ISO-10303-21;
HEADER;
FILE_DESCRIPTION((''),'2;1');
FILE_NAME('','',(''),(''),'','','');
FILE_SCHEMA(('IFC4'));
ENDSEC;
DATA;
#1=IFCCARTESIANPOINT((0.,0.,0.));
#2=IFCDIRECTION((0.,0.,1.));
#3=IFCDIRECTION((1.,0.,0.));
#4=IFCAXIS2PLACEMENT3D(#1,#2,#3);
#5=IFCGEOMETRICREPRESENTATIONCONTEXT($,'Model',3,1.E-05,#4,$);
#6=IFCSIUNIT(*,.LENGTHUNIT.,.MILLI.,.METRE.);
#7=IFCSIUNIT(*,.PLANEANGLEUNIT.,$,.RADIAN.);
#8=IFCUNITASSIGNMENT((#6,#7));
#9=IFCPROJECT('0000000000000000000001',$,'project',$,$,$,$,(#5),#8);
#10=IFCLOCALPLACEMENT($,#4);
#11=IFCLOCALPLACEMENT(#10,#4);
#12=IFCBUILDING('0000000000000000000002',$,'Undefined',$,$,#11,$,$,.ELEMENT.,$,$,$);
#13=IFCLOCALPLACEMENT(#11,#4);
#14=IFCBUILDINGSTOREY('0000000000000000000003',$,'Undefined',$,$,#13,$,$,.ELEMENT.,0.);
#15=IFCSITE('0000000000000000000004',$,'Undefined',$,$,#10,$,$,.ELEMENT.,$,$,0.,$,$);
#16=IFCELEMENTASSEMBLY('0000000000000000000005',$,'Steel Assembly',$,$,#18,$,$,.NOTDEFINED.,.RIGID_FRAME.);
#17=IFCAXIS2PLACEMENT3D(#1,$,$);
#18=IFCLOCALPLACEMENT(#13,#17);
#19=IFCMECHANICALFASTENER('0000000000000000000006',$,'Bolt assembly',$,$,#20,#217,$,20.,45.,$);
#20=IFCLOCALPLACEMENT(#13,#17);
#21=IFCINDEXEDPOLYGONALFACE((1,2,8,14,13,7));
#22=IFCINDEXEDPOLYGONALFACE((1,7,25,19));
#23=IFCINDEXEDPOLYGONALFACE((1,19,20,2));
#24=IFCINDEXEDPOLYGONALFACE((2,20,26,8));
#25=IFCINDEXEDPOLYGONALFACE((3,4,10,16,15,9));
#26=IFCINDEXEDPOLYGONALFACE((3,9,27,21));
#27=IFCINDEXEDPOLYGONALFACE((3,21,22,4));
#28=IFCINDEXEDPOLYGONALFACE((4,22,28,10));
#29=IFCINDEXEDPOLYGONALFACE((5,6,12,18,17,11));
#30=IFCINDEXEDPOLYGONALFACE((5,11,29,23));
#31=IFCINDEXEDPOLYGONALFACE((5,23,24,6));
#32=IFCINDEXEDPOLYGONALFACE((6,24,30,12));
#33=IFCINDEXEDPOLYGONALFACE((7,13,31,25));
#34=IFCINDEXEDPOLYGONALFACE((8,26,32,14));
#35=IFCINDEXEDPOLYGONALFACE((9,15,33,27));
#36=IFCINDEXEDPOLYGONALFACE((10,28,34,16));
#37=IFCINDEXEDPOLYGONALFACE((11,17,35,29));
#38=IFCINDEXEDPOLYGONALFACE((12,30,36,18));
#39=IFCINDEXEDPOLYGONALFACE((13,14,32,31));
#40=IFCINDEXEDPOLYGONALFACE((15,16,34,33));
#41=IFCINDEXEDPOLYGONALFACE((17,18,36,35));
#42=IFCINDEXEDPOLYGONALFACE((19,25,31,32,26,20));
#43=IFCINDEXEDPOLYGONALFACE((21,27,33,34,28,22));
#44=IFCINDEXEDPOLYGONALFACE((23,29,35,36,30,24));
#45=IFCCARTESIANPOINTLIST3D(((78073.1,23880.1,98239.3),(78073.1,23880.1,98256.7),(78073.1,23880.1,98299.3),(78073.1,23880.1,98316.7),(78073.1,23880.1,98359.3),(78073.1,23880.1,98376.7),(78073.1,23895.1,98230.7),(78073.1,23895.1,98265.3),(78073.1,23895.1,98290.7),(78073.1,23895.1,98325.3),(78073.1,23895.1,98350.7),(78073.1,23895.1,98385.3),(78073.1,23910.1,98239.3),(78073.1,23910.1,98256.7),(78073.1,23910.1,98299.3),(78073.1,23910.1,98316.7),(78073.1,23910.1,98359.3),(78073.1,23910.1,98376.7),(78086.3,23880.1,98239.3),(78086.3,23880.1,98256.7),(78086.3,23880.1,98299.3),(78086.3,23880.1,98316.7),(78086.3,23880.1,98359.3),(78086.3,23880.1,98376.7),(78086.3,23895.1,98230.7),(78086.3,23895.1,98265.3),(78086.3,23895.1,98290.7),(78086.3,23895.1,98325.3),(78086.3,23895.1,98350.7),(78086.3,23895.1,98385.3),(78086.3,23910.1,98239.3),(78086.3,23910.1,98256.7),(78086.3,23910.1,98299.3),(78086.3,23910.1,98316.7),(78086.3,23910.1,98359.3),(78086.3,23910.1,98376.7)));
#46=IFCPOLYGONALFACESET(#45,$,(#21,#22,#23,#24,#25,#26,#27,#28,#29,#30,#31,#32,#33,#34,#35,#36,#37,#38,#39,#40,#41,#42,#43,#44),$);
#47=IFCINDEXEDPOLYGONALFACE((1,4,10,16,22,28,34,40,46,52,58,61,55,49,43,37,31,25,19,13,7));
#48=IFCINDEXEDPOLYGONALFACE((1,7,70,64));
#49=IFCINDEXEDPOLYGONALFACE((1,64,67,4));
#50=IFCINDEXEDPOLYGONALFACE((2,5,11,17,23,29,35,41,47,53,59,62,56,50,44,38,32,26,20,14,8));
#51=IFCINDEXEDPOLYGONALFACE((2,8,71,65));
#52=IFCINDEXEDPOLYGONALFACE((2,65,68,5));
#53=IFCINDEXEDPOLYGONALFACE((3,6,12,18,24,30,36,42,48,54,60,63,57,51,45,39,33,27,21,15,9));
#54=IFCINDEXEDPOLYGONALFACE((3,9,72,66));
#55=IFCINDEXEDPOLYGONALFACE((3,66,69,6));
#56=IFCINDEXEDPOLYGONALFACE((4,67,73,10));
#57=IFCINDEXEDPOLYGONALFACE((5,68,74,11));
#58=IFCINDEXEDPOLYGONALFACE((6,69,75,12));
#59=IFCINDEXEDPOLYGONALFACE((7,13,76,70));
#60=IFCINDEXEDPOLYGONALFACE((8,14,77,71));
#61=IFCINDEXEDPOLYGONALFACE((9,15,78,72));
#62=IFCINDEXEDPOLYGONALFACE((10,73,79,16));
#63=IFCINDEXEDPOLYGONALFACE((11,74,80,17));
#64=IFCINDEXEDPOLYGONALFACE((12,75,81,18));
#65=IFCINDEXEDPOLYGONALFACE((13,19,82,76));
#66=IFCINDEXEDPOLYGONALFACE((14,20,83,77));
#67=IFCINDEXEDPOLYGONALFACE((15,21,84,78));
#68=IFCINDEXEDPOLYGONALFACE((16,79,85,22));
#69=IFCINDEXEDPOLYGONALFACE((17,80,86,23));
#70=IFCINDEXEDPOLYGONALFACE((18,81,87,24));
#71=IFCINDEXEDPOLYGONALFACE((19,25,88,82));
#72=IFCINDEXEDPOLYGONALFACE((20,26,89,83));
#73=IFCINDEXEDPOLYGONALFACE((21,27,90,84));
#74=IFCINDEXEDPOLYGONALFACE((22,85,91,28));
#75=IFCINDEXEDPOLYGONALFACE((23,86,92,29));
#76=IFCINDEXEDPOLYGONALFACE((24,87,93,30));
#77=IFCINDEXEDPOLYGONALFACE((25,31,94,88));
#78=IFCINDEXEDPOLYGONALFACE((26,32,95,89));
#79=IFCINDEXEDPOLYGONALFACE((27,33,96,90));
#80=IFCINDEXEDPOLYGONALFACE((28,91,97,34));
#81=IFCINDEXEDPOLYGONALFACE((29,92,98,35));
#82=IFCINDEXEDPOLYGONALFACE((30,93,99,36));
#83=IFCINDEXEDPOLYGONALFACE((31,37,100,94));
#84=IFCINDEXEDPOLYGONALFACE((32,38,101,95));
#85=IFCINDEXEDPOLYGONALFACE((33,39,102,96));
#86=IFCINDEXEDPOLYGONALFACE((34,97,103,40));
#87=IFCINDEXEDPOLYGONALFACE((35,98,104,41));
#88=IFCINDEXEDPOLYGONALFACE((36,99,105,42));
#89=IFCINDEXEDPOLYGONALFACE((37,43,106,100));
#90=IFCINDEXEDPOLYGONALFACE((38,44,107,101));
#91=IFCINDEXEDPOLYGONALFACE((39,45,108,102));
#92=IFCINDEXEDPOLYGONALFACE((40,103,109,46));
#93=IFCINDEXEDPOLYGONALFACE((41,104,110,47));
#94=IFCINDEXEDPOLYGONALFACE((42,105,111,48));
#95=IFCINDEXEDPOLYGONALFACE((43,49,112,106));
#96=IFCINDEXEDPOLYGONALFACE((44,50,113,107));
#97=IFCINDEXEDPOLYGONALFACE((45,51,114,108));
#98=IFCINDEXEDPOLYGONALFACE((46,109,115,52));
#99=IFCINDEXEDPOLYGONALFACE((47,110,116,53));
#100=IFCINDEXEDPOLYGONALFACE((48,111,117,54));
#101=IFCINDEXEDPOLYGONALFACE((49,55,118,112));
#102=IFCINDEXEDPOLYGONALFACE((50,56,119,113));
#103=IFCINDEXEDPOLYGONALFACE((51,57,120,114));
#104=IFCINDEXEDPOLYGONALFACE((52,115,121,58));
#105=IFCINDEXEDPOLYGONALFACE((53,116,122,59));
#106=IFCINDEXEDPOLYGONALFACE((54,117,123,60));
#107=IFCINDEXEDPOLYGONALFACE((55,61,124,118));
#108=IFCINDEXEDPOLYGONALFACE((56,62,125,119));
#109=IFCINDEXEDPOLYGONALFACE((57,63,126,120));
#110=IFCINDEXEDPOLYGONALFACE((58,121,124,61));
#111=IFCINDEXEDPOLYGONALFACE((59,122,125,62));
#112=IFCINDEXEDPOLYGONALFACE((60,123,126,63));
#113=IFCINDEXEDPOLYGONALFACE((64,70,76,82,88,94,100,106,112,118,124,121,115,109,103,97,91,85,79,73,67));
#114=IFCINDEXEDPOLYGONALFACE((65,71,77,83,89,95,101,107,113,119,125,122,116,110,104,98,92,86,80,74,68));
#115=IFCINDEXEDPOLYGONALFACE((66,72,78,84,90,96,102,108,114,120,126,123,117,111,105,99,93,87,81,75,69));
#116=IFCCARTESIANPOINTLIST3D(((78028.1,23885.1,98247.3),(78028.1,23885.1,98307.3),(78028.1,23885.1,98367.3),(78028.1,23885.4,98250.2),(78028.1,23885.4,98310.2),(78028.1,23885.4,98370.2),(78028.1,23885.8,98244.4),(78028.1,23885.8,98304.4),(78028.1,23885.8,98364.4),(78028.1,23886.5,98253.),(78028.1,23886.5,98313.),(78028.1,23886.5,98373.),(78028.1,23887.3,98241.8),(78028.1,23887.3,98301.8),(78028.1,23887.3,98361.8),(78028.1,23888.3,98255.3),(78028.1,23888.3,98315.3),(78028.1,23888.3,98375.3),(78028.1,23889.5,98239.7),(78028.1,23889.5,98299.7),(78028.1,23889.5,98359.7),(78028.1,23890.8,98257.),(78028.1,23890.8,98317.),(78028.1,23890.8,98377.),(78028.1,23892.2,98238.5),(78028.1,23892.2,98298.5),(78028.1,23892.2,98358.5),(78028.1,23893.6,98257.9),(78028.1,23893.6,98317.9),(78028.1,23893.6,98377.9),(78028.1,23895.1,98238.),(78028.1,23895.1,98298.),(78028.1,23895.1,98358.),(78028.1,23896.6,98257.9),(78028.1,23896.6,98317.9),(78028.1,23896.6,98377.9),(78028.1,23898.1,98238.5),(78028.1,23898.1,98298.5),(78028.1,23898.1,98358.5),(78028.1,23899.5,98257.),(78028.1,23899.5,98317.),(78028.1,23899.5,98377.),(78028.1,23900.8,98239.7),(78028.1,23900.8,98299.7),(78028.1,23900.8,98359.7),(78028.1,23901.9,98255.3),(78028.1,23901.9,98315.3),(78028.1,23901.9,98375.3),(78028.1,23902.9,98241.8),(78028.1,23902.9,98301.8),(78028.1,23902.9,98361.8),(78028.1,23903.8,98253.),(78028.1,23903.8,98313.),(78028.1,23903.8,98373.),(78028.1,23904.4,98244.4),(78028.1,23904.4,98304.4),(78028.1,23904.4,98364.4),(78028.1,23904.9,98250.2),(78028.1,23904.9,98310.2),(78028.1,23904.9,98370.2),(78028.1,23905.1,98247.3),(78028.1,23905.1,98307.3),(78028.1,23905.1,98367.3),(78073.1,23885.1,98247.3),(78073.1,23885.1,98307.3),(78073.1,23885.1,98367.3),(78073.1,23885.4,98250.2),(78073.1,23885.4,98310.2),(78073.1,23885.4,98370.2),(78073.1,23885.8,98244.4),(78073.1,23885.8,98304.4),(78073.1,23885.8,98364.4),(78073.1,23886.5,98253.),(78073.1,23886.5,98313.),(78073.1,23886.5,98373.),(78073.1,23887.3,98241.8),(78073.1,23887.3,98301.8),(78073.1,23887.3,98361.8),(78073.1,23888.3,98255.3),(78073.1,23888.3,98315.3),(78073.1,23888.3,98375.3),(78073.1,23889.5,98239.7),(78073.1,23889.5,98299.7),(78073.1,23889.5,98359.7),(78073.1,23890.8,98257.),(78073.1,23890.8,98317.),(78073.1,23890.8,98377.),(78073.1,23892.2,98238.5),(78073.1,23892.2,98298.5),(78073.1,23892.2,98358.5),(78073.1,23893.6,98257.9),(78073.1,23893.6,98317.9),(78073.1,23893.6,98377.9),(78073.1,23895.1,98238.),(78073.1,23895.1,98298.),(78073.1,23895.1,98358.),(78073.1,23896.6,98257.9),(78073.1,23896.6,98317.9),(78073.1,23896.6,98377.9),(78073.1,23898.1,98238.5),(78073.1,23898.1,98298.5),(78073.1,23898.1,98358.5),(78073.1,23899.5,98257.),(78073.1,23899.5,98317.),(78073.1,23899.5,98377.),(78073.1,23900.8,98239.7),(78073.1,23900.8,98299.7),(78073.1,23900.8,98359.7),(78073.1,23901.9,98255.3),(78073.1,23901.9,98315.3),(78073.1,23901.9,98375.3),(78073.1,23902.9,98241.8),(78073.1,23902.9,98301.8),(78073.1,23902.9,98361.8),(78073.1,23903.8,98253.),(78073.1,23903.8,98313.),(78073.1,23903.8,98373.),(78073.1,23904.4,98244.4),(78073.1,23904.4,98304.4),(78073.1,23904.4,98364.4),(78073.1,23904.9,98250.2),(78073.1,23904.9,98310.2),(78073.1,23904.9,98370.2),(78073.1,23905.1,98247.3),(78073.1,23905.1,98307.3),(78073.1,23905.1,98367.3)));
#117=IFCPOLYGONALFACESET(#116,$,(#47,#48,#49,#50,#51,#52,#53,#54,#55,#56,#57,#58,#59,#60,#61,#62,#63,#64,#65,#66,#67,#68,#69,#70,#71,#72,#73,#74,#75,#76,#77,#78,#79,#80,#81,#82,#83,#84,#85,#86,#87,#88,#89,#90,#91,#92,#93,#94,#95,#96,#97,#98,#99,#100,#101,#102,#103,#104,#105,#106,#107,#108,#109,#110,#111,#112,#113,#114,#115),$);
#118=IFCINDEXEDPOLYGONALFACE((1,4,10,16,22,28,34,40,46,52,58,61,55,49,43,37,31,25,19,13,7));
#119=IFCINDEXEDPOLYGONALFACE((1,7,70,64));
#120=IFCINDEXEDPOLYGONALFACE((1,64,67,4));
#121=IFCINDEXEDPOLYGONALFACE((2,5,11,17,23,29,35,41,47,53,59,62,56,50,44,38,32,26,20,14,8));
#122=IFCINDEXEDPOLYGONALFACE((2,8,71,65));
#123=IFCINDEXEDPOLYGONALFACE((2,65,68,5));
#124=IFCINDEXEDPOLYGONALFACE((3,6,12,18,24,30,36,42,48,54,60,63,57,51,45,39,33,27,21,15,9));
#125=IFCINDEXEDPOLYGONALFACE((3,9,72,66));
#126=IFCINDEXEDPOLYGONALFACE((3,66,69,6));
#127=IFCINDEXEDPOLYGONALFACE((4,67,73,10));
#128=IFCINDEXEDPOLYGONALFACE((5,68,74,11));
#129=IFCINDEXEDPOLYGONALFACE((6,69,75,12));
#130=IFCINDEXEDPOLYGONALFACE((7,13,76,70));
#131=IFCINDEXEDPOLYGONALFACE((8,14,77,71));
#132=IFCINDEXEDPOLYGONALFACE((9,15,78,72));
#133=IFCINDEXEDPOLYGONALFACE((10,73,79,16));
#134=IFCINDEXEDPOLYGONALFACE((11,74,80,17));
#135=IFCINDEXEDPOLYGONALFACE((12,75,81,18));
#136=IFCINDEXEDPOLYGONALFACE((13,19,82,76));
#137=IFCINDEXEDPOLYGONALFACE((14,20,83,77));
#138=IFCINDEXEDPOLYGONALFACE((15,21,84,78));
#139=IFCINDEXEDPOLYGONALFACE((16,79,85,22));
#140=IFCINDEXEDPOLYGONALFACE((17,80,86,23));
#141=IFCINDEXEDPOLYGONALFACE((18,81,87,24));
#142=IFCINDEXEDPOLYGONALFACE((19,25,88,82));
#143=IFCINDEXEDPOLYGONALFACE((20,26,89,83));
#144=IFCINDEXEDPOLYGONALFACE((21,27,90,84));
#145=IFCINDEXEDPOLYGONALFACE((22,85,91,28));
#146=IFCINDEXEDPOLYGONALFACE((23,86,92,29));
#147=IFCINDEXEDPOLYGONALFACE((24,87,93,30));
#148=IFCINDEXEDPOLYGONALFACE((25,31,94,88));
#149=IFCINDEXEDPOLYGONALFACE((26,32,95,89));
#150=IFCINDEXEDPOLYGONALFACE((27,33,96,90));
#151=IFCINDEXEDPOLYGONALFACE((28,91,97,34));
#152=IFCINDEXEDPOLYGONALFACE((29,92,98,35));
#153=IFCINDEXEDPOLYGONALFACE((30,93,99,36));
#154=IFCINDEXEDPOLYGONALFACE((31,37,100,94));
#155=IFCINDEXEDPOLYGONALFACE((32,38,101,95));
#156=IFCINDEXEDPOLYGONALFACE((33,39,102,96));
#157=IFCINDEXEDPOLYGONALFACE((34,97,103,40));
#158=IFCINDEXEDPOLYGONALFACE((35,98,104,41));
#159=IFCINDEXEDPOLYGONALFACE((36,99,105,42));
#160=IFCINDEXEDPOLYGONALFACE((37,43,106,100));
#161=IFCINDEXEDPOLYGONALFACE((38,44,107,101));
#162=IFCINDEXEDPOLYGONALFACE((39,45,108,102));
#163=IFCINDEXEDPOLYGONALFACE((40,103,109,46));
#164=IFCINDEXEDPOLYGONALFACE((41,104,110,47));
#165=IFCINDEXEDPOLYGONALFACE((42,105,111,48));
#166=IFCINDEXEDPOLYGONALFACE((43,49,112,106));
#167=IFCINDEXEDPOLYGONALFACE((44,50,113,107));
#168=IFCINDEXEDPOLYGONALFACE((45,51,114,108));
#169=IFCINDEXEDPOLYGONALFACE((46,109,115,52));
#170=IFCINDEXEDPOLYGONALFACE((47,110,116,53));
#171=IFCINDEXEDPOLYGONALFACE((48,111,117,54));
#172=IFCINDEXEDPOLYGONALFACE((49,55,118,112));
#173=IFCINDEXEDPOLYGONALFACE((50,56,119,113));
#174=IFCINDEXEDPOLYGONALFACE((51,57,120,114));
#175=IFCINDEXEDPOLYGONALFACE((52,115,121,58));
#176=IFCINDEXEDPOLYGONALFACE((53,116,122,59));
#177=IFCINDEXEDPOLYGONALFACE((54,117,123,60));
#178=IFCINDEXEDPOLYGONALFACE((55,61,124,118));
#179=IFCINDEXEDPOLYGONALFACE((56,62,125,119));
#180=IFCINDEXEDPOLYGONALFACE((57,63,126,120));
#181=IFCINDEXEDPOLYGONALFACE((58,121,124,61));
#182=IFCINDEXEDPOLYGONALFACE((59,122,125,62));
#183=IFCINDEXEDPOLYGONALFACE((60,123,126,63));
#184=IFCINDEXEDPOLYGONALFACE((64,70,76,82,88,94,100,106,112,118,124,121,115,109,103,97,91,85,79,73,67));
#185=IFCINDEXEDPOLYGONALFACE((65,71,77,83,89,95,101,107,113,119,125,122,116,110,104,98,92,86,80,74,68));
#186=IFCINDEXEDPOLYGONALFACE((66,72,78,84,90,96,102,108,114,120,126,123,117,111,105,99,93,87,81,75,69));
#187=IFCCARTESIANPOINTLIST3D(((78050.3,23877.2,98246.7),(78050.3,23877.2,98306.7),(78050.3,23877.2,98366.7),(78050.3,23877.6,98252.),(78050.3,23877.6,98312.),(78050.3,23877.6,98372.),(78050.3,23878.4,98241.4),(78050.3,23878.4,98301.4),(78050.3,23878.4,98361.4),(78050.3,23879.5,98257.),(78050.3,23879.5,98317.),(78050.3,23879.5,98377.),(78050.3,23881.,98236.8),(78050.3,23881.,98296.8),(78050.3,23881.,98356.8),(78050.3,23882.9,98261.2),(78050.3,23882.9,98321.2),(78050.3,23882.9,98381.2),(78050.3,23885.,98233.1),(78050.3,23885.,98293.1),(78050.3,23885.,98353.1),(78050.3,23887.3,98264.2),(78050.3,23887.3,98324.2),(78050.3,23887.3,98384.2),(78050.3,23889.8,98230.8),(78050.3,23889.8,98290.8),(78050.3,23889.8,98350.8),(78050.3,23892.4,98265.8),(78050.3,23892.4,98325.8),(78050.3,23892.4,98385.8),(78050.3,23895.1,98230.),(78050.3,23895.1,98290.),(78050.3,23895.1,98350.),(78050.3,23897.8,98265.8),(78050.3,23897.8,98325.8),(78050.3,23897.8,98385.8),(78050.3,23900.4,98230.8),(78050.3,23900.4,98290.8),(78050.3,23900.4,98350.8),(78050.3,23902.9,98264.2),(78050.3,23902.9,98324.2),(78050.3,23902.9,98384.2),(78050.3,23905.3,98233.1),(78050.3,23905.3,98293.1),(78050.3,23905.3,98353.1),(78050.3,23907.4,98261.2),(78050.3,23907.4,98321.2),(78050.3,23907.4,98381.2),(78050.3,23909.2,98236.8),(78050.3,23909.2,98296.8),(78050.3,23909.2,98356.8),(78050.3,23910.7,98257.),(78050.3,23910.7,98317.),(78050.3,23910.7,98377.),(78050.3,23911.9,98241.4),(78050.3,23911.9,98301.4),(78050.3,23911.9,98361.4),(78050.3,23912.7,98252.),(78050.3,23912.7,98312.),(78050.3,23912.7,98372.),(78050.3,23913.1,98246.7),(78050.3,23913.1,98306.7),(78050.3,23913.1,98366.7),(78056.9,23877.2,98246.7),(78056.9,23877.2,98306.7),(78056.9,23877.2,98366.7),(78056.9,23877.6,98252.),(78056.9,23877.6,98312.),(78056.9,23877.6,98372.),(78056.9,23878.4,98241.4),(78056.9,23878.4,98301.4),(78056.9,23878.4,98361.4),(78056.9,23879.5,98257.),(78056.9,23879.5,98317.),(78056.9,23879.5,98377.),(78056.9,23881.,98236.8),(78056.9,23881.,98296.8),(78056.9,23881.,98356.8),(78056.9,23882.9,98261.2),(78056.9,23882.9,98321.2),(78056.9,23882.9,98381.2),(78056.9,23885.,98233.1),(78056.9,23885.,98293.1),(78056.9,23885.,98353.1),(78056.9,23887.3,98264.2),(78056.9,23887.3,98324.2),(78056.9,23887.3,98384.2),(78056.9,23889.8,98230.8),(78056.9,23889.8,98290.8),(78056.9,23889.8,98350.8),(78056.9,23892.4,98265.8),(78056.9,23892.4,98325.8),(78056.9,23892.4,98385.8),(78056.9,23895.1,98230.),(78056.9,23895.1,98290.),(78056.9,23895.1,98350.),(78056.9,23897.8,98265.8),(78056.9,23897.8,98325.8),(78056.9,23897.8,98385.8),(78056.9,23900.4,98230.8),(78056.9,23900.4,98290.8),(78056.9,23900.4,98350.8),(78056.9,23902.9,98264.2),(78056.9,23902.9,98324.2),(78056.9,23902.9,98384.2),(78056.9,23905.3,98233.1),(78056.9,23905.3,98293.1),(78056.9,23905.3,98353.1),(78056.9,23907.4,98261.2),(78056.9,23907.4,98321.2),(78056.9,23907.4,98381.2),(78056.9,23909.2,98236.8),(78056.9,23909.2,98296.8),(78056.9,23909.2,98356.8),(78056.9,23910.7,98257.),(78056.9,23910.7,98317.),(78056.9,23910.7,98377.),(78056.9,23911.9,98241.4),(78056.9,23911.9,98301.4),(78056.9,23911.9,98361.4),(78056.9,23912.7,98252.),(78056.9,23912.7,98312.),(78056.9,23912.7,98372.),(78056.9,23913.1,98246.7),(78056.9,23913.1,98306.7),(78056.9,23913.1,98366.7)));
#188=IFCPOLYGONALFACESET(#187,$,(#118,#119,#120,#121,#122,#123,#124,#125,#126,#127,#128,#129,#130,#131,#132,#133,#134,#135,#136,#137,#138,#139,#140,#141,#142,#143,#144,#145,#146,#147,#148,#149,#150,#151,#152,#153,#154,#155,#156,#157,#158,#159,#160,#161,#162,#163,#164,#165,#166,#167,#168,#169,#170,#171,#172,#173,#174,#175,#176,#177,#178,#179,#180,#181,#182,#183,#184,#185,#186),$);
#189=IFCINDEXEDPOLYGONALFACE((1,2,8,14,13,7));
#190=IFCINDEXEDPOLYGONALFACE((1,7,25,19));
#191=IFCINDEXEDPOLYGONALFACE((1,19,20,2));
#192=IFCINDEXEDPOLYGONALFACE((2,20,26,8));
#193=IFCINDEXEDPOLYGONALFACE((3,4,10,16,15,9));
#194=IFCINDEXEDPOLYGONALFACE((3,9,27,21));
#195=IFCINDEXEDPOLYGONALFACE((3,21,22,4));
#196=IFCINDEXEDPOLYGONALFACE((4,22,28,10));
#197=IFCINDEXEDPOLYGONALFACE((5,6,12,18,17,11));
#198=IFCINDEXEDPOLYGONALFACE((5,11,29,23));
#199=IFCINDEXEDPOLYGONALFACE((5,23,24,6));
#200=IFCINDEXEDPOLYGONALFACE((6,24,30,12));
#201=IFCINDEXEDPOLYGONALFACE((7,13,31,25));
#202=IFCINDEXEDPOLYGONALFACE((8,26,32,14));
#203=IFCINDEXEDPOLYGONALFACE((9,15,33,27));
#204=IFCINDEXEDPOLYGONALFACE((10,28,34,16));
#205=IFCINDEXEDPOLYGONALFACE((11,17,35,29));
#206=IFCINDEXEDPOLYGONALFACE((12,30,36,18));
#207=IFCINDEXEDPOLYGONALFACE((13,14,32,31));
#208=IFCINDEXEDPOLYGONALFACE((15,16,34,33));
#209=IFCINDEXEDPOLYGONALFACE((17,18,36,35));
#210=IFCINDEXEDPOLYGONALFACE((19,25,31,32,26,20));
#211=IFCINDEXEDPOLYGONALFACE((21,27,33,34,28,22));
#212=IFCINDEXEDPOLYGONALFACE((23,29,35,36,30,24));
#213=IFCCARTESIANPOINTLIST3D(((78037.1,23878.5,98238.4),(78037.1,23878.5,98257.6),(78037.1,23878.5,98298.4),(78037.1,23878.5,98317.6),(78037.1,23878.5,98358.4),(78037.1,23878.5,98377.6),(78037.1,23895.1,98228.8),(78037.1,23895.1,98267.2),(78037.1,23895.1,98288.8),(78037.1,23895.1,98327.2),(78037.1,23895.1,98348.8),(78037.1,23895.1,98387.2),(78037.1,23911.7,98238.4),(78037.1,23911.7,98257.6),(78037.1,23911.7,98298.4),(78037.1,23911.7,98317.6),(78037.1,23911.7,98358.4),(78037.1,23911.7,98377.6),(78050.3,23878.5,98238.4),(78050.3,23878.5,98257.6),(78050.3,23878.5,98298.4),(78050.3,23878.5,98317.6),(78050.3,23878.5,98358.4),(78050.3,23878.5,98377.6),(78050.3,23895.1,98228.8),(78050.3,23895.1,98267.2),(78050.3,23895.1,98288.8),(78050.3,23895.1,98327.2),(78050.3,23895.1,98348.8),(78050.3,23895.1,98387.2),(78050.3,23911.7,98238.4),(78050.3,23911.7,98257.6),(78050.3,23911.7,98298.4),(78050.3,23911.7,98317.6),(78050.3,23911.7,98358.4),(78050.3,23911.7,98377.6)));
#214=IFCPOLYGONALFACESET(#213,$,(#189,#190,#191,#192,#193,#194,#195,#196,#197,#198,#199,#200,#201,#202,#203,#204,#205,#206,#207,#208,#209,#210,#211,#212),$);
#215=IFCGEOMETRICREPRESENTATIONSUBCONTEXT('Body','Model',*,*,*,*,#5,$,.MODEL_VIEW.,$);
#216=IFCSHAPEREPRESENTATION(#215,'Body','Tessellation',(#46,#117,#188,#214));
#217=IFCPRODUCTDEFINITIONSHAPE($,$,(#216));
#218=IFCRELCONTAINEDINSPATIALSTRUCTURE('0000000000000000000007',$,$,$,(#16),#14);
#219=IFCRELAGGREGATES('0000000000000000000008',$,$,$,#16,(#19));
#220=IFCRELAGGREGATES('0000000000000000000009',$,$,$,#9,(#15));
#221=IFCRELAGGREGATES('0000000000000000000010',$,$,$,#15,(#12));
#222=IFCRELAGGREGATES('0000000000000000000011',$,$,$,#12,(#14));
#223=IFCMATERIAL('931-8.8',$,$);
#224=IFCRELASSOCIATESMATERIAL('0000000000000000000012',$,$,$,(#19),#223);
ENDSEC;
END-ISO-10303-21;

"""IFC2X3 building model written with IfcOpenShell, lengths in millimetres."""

from ifc_helpers import new_model, si_unit, frame, origin_with_axes, origin_2d_with_axis, place, context, subcontext, project, spatial, polyline, circle, outline, extrude, source, transform, mapped, material, element, aggregate, save


model = new_model("IFC2X3")

# Units and contexts
model_context = context("Model", 3, precision=1e-05, world=origin_with_axes())
body_context = subcontext(model_context, "Body", "Model", "MODEL_VIEW")
ifc_project = project(units=[si_unit("LENGTHUNIT", "METRE", prefix="MILLI"), si_unit("PLANEANGLEUNIT", "RADIAN")], contexts=[model_context])

# Site, building, storey
site_placement = place(None, origin_with_axes())
site = spatial("IfcSite", under=ifc_project, at=site_placement, Name="Undefined", CompositionType="ELEMENT", RefElevation=0.0)
building_placement = place(site_placement, origin_with_axes())
building = spatial("IfcBuilding", under=site, at=building_placement, Name="Undefined", CompositionType="ELEMENT")
storey_placement = place(building_placement, origin_with_axes())
storey = spatial("IfcBuildingStorey", under=building, at=storey_placement, Name="Undefined", CompositionType="ELEMENT", Elevation=0.0)

# Element assembly, mechanical fastener
assembly_1_placement = place(storey_placement, origin_with_axes())
assembly_1 = element("IfcElementAssembly", 1, at=assembly_1_placement, inside=storey, Name="Steel Assembly", AssemblyPlace="NOTDEFINED", PredefinedType="RIGID_FRAME")
ifc_material_1 = material(Name="931-8.8")
shared_shape_1 = source(origin_with_axes(), body_context, "Body", "SweptSolid", [
    extrude(outline(polyline([(17.3, 0.0), (8.7, 15.0), (-8.7, 15.0), (-17.3, 0.0), (-8.7, -15.0), (8.7, -15.0), (17.3, 0.0)])), frame((0.0, -23.2, 0.0), z_axis=(0.0, 1.0, 0.0), x_axis=(1.0, 0.0, 0.0)), (0.0, 0.0, 1.0), 13.2),
    extrude(circle(Radius=10.0, at=origin_2d_with_axis()), frame((0.0, -10.0, 0.0), z_axis=(0.0, 1.0, 0.0), x_axis=(1.0, 0.0, 0.0)), (0.0, 0.0, 1.0), 45.0),
    extrude(circle(Radius=18.0, at=origin_2d_with_axis()), frame((0.0, 6.2, 0.0), z_axis=(0.0, 1.0, 0.0), x_axis=(1.0, 0.0, 0.0)), (0.0, 0.0, 1.0), 6.6),
    extrude(outline(polyline([(19.2, 0.0), (9.6, 16.6), (-9.6, 16.6), (-19.2, 0.0), (-9.6, -16.6), (9.6, -16.6), (19.2, 0.0)])), frame((0.0, 12.8, 0.0), z_axis=(0.0, 1.0, 0.0), x_axis=(1.0, 0.0, 0.0)), (0.0, 0.0, 1.0), 13.2),
])
mechanical_fastener_1_placement = place(assembly_1_placement, frame((78063.1, 23895.1, 98368.0), z_axis=(0.0, 1.0, 0.0), x_axis=(0.0, 0.0, -1.0)))
mechanical_fastener_1 = element("IfcMechanicalFastener", 2, at=mechanical_fastener_1_placement, material=ifc_material_1, Name="Bolt assembly", NominalDiameter=20.0, NominalLength=45.0, context=body_context, shape_type="MappedRepresentation", body=[
    mapped(shared_shape_1, transform((0.0, 0.0, 0.0))),
    mapped(shared_shape_1, transform((60.0, 0.0, 0.0))),
    mapped(shared_shape_1, transform((120.0, 0.0, 0.0))),
])

aggregate(assembly_1, [mechanical_fastener_1])

save(model, "model.ifc")
